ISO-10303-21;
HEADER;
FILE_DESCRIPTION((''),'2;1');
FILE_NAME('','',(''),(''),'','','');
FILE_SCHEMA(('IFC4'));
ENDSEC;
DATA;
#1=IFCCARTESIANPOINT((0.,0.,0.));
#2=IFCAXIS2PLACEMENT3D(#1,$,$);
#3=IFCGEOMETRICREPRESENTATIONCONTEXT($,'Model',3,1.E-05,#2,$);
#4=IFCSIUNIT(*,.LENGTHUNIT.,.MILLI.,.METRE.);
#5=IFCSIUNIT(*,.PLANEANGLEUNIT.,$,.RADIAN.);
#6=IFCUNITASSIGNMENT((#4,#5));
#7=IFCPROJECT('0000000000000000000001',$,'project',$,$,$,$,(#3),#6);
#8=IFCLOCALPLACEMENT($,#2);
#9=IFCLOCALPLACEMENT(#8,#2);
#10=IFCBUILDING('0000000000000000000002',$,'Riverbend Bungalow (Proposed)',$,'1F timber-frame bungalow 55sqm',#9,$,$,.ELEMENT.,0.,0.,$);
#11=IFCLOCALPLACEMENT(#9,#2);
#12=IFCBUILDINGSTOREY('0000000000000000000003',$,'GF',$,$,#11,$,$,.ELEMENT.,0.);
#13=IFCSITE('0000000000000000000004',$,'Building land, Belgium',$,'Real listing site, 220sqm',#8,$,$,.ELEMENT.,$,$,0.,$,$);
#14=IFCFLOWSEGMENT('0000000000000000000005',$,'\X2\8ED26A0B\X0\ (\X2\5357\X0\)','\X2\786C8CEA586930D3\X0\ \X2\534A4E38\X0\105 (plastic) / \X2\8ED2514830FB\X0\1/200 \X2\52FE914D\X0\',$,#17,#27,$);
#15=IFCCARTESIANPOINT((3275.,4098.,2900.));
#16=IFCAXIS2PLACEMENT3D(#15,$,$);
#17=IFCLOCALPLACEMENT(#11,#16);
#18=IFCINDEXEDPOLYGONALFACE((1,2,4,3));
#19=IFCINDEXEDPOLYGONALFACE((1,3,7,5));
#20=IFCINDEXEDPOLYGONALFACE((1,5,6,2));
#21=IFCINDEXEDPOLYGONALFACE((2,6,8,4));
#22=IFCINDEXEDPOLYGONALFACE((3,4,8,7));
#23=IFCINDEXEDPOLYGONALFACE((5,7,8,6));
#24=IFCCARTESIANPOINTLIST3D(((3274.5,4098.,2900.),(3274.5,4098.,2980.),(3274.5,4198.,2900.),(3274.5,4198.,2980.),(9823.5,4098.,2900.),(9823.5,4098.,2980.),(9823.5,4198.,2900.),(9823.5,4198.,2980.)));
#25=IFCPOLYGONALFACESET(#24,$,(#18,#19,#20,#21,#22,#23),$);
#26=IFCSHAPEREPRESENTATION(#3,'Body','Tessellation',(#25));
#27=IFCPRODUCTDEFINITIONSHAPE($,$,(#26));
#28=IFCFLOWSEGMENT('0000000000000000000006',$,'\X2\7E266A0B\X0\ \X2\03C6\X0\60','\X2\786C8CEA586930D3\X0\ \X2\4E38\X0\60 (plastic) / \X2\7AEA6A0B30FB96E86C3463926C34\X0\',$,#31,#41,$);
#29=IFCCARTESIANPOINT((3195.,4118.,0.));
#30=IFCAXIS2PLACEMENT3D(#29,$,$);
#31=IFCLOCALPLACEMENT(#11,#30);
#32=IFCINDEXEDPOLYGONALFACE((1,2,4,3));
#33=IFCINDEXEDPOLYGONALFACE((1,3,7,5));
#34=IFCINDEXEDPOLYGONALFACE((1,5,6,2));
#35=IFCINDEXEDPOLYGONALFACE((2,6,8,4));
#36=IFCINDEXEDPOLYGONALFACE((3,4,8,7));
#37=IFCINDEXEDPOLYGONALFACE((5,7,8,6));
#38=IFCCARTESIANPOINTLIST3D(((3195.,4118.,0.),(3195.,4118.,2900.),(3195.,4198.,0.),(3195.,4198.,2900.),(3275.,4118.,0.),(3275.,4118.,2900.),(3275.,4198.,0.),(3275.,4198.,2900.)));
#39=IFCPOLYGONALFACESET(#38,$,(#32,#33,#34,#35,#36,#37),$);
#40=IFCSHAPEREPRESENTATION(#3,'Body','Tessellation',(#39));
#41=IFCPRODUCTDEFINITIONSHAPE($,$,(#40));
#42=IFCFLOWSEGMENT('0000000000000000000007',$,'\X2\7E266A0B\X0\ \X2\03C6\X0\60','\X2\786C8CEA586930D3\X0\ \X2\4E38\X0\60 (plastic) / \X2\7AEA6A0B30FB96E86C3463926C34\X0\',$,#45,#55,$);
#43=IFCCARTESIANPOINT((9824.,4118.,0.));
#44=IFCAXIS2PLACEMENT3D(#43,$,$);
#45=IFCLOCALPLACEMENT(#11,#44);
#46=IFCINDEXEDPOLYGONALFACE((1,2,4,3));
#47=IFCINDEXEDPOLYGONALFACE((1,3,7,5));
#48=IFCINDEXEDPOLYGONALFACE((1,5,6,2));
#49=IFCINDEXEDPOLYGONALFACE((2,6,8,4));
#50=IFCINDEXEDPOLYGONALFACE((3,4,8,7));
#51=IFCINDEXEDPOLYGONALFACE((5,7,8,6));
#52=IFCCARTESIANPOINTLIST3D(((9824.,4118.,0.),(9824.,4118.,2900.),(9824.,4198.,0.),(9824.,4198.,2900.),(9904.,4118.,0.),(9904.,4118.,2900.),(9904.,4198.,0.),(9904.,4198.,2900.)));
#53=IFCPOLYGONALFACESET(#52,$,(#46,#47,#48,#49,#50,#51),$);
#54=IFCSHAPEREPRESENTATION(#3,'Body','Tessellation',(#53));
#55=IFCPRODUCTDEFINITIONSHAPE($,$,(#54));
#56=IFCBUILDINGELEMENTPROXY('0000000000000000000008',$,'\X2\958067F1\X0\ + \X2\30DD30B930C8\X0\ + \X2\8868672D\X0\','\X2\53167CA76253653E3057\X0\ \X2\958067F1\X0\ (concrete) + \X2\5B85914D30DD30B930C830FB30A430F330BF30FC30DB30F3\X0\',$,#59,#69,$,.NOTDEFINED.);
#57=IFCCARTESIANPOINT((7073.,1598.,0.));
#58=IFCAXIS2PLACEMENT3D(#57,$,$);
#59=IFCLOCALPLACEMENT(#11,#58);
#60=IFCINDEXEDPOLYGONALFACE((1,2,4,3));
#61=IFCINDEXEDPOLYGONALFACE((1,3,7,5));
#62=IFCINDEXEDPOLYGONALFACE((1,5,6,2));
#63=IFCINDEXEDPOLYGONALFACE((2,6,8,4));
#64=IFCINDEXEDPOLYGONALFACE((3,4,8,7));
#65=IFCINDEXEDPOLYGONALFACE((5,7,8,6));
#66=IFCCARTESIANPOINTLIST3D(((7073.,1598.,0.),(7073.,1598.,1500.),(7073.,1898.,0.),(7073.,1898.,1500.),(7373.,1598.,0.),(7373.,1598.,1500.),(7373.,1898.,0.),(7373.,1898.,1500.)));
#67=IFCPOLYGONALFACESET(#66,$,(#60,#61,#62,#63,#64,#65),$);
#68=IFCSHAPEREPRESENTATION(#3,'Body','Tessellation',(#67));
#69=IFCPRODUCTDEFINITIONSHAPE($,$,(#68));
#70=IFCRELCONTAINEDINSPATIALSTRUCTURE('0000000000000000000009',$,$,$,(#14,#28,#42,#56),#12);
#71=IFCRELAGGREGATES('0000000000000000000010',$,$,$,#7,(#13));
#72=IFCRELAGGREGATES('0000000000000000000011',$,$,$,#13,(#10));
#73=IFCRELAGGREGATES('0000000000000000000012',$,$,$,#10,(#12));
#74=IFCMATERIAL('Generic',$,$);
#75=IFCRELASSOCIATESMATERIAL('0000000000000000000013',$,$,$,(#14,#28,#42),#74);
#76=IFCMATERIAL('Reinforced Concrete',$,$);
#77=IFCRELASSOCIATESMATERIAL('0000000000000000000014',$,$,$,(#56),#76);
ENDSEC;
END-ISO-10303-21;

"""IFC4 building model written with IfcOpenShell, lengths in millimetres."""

from ifc_helpers import new_model, si_unit, frame, frame_2d, origin, place, context, project, spatial, rectangle, extrude, material, element, save


model = new_model("IFC4")

# Units and contexts
model_context = context("Model", 3, precision=1e-05, world=origin())
ifc_project = project(units=[si_unit("LENGTHUNIT", "METRE", prefix="MILLI"), si_unit("PLANEANGLEUNIT", "RADIAN")], contexts=[model_context])

# Site, building, storey
site_placement = place(None, origin())
site = spatial("IfcSite", under=ifc_project, at=site_placement, Name="Building land, Belgium", ObjectType="Real listing site, 220sqm", CompositionType="ELEMENT", RefElevation=0.0)
building_placement = place(site_placement, origin())
building = spatial("IfcBuilding", under=site, at=building_placement, Name="Riverbend Bungalow (Proposed)", ObjectType="1F timber-frame bungalow 55sqm", CompositionType="ELEMENT", ElevationOfRefHeight=0.0, ElevationOfTerrain=0.0)
storey_placement = place(building_placement, origin())
storey = spatial("IfcBuildingStorey", under=building, at=storey_placement, Name="GF", CompositionType="ELEMENT", Elevation=0.0)

# Shared definitions
ifc_material_1 = material(Name="Reinforced Concrete")

# Shared definitions
ifc_material_2 = material(Name="Generic")

# Flow segments
flow_segment_1_placement = place(storey_placement, frame((3275.0, 4098.0, 2900.0)))
element("IfcFlowSegment", 1, at=flow_segment_1_placement, inside=storey, material=ifc_material_2, Name="軒樋 (南)", Description="硬質塩ビ 半丸105 (plastic) / 軒先・1/200 勾配", context=model_context, shape_type="SweptSolid", body=[
    extrude(rectangle(XDim=6549.0, YDim=100.0, at=frame_2d((3274.0, 50.0))), frame((3275.0, 4098.0, 2900.0)), (0.0, 0.0, 1.0), 80.0),
])
flow_segment_2_placement = place(storey_placement, frame((3195.0, 4118.0, 0.0)))
element("IfcFlowSegment", 2, at=flow_segment_2_placement, inside=storey, material=ifc_material_2, Name="縦樋 φ60", Description="硬質塩ビ 丸60 (plastic) / 竪樋・雨水排水", context=model_context, shape_type="SweptSolid", body=[
    extrude(rectangle(XDim=80.0, YDim=80.0, at=frame_2d((40.0, 40.0))), frame((3195.0, 4118.0, 0.0)), (0.0, 0.0, 1.0), 2900.0),
])
flow_segment_3_placement = place(storey_placement, frame((9824.0, 4118.0, 0.0)))
element("IfcFlowSegment", 3, at=flow_segment_3_placement, inside=storey, material=ifc_material_2, Name="縦樋 φ60", Description="硬質塩ビ 丸60 (plastic) / 竪樋・雨水排水", context=model_context, shape_type="SweptSolid", body=[
    extrude(rectangle(XDim=80.0, YDim=80.0, at=frame_2d((40.0, 40.0))), frame((9824.0, 4118.0, 0.0)), (0.0, 0.0, 1.0), 2900.0),
])

# Building element proxy
proxy_placement = place(storey_placement, frame((7073.0, 1598.0, 0.0)))
element("IfcBuildingElementProxy", 4, at=proxy_placement, inside=storey, material=ifc_material_1, Name="門柱 + ポスト + 表札", Description="化粧打放し 門柱 (concrete) + 宅配ポスト・インターホン", PredefinedType="NOTDEFINED", context=model_context, shape_type="SweptSolid", body=[
    extrude(rectangle(XDim=300.0, YDim=300.0, at=frame_2d((150.0, 150.0))), frame((7073.0, 1598.0, 0.0)), (0.0, 0.0, 1.0), 1500.0),
])

save(model, "model.ifc")
